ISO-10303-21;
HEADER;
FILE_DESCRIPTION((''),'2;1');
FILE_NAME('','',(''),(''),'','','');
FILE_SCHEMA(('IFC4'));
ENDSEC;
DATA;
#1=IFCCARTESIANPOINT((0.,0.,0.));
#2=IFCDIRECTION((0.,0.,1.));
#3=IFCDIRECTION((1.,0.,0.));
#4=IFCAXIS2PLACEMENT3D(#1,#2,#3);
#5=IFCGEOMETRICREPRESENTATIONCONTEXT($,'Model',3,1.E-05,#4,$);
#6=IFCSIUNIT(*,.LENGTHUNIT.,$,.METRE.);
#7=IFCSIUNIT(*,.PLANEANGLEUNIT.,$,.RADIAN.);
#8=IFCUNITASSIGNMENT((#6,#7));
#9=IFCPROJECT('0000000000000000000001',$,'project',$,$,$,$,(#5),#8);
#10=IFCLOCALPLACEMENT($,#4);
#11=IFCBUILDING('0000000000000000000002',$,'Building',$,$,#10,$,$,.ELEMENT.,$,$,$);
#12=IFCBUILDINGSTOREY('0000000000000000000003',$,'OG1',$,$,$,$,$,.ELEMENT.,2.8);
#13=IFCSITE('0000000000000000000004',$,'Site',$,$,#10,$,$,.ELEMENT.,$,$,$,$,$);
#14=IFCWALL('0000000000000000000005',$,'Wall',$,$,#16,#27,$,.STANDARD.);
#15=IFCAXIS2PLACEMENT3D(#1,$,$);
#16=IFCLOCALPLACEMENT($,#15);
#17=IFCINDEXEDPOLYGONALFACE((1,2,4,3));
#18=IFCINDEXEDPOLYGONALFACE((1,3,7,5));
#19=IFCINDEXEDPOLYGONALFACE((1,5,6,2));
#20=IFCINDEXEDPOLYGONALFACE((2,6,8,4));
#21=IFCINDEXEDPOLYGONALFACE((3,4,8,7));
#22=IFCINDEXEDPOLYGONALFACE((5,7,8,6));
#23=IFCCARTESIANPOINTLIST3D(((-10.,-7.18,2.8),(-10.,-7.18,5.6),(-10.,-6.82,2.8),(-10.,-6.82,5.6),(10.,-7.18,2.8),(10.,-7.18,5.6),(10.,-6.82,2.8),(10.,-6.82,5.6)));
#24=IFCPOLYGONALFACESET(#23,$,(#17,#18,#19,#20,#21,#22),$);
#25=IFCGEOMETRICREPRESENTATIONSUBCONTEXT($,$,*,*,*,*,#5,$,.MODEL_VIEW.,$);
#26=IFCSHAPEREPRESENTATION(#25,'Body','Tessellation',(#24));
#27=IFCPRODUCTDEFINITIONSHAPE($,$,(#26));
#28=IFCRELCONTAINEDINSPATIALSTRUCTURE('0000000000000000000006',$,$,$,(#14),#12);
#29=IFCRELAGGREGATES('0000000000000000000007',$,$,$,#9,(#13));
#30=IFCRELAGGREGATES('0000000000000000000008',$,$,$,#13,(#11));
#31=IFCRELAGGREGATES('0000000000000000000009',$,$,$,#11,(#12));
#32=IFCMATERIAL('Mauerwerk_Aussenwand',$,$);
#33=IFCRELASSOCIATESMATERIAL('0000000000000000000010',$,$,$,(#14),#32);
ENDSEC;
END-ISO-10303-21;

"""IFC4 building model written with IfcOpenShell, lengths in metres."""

from ifc_helpers import new_model, si_unit, frame, frame_2d, origin, origin_with_axes, place, context, subcontext, project, spatial, rectangle, extrude, material, element, save


model = new_model("IFC4")

# Units and contexts
model_context = context("Model", 3, precision=1e-05, world=origin_with_axes())
sub_context = subcontext(model_context, None, None, "MODEL_VIEW")
ifc_project = project(units=[si_unit("LENGTHUNIT", "METRE"), si_unit("PLANEANGLEUNIT", "RADIAN")], contexts=[model_context])

# Site, building, storey
placement_1 = place(None, origin_with_axes())
site = spatial("IfcSite", under=ifc_project, at=placement_1, Name="Site", CompositionType="ELEMENT")
building = spatial("IfcBuilding", under=site, at=placement_1, Name="Building", CompositionType="ELEMENT")
storey = spatial("IfcBuildingStorey", under=building, Name="OG1", CompositionType="ELEMENT", Elevation=2.8)

# Wall
ifc_material = material(Name="Mauerwerk_Aussenwand")
placement_2 = place(None, origin_with_axes())
placement_3 = place(placement_2, frame((0.0, 0.0, 2.8)))
wall_placement = place(placement_3, frame((-10.0, -7.0, 0.0), x_axis=(1.0, 0.0, 0.0)))
element("IfcWall", 1, at=wall_placement, inside=storey, material=ifc_material, Name="Wall", PredefinedType="STANDARD", context=sub_context, shape_type="SweptSolid", body=[
    extrude(rectangle(XDim=20.0, YDim=0.36, at=frame_2d((10.0, 0.0))), origin(), (0.0, 0.0, 1.0), 2.8),
])

save(model, "model.ifc")
